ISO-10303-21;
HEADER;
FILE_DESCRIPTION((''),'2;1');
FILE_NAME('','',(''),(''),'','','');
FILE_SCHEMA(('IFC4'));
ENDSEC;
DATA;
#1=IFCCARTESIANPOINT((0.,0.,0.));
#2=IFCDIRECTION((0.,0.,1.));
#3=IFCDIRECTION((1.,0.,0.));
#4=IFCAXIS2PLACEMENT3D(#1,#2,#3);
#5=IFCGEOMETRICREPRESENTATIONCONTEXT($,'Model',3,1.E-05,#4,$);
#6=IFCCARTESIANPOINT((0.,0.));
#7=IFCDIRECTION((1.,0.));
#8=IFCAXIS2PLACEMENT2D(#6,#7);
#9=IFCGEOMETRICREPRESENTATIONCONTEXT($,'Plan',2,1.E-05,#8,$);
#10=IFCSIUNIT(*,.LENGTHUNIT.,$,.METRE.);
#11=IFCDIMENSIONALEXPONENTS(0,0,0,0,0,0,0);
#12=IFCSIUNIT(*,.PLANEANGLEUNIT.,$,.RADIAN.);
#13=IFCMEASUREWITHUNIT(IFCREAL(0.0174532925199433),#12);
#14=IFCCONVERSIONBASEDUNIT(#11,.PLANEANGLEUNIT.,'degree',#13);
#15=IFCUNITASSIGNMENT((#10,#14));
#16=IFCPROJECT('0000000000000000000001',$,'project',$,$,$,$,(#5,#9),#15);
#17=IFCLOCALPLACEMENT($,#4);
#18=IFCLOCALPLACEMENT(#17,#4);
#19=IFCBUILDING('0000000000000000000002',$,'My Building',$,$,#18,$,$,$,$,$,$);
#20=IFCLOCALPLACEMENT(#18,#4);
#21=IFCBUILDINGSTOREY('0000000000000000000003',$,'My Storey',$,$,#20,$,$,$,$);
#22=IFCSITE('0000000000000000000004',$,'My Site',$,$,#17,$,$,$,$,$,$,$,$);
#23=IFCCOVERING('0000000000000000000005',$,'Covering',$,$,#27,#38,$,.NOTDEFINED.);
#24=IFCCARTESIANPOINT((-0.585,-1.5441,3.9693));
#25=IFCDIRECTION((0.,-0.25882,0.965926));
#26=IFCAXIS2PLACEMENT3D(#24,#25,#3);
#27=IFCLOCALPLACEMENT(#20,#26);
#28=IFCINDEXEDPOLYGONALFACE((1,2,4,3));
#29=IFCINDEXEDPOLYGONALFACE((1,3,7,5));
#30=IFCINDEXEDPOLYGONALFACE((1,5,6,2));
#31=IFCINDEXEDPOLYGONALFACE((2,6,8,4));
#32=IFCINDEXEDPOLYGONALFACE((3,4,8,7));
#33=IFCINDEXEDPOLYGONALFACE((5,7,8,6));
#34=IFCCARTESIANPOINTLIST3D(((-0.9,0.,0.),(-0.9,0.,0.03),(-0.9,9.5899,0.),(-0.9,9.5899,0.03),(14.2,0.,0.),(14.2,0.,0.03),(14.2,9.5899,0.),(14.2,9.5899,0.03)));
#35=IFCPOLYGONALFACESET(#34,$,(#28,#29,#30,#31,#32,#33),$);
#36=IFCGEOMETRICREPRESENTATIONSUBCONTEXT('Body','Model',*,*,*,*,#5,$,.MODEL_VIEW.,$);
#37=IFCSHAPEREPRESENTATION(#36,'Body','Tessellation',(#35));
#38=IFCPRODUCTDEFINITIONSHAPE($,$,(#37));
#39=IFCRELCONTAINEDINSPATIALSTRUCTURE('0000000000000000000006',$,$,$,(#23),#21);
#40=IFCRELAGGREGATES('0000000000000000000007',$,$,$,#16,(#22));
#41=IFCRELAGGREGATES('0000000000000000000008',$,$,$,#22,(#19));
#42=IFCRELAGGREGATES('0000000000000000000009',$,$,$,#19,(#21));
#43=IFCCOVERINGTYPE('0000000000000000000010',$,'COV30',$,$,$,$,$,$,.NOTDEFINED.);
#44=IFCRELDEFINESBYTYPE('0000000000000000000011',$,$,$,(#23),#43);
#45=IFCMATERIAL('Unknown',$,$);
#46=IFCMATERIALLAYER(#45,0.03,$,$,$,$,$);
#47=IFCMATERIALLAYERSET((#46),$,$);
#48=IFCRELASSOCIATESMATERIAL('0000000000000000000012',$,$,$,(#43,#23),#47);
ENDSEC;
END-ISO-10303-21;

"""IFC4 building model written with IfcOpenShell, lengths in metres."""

from ifc_helpers import new_model, entity, si_unit, converted_unit, frame, origin_with_axes, origin_2d_with_axis, place, context, subcontext, project, spatial, line, indexed_curve, outline, extrude, material, layer, layer_set, layer_usage, type_object, element, save


model = new_model("IFC4")

# Units and contexts
model_context = context("Model", 3, precision=1e-05, world=origin_with_axes())
plan_context = context("Plan", 2, precision=1e-05, world=origin_2d_with_axis())
body_context = subcontext(model_context, "Body", "Model", "MODEL_VIEW")
ifc_project = project(units=[si_unit("LENGTHUNIT", "METRE"), converted_unit("PLANEANGLEUNIT", "degree", entity("IfcReal", 0.0174532925199433), si_unit("PLANEANGLEUNIT", "RADIAN"), dimensions=[0, 0, 0, 0, 0, 0, 0])], contexts=[model_context, plan_context])

# Site, building, storey
site_placement = place(None, origin_with_axes())
site = spatial("IfcSite", under=ifc_project, at=site_placement, Name="My Site")
building_placement = place(site_placement, origin_with_axes())
building = spatial("IfcBuilding", under=site, at=building_placement, Name="My Building")
storey_placement = place(building_placement, origin_with_axes())
storey = spatial("IfcBuildingStorey", under=building, at=storey_placement, Name="My Storey")

# Shared definitions
ifc_material_1 = material(Name="Unknown")

# Covering
ifc_layer_1 = layer(ifc_material_1, 0.03)
ifc_layer_set_1 = layer_set([ifc_layer_1])
ifc_layer_usage_1 = layer_usage(ifc_layer_set_1, "AXIS3", "POSITIVE", 0.0)
covering_type = type_object("IfcCoveringType", Name="COV30", PredefinedType="NOTDEFINED", material=ifc_layer_set_1)
covering_placement = place(storey_placement, frame((-0.585, -1.5441, 3.9693), z_axis=(0.0, -0.25882, 0.965926), x_axis=(1.0, 0.0, 0.0)))
element("IfcCovering", 1, at=covering_placement, inside=storey, type_object=covering_type, material=ifc_layer_usage_1, Name="Covering", PredefinedType="NOTDEFINED", context=body_context, shape_type="SweptSolid", body=[
    extrude(outline(indexed_curve([(-0.9, 0.0), (14.2, 0.0), (14.2, 9.5899), (-0.9, 9.5899)], segments=[line(3, 2), line(2, 1), line(1, 4), line(4, 3)], self_intersect=False)), None, (0.0, 0.0, 1.0), 0.03),
])

save(model, "model.ifc")
